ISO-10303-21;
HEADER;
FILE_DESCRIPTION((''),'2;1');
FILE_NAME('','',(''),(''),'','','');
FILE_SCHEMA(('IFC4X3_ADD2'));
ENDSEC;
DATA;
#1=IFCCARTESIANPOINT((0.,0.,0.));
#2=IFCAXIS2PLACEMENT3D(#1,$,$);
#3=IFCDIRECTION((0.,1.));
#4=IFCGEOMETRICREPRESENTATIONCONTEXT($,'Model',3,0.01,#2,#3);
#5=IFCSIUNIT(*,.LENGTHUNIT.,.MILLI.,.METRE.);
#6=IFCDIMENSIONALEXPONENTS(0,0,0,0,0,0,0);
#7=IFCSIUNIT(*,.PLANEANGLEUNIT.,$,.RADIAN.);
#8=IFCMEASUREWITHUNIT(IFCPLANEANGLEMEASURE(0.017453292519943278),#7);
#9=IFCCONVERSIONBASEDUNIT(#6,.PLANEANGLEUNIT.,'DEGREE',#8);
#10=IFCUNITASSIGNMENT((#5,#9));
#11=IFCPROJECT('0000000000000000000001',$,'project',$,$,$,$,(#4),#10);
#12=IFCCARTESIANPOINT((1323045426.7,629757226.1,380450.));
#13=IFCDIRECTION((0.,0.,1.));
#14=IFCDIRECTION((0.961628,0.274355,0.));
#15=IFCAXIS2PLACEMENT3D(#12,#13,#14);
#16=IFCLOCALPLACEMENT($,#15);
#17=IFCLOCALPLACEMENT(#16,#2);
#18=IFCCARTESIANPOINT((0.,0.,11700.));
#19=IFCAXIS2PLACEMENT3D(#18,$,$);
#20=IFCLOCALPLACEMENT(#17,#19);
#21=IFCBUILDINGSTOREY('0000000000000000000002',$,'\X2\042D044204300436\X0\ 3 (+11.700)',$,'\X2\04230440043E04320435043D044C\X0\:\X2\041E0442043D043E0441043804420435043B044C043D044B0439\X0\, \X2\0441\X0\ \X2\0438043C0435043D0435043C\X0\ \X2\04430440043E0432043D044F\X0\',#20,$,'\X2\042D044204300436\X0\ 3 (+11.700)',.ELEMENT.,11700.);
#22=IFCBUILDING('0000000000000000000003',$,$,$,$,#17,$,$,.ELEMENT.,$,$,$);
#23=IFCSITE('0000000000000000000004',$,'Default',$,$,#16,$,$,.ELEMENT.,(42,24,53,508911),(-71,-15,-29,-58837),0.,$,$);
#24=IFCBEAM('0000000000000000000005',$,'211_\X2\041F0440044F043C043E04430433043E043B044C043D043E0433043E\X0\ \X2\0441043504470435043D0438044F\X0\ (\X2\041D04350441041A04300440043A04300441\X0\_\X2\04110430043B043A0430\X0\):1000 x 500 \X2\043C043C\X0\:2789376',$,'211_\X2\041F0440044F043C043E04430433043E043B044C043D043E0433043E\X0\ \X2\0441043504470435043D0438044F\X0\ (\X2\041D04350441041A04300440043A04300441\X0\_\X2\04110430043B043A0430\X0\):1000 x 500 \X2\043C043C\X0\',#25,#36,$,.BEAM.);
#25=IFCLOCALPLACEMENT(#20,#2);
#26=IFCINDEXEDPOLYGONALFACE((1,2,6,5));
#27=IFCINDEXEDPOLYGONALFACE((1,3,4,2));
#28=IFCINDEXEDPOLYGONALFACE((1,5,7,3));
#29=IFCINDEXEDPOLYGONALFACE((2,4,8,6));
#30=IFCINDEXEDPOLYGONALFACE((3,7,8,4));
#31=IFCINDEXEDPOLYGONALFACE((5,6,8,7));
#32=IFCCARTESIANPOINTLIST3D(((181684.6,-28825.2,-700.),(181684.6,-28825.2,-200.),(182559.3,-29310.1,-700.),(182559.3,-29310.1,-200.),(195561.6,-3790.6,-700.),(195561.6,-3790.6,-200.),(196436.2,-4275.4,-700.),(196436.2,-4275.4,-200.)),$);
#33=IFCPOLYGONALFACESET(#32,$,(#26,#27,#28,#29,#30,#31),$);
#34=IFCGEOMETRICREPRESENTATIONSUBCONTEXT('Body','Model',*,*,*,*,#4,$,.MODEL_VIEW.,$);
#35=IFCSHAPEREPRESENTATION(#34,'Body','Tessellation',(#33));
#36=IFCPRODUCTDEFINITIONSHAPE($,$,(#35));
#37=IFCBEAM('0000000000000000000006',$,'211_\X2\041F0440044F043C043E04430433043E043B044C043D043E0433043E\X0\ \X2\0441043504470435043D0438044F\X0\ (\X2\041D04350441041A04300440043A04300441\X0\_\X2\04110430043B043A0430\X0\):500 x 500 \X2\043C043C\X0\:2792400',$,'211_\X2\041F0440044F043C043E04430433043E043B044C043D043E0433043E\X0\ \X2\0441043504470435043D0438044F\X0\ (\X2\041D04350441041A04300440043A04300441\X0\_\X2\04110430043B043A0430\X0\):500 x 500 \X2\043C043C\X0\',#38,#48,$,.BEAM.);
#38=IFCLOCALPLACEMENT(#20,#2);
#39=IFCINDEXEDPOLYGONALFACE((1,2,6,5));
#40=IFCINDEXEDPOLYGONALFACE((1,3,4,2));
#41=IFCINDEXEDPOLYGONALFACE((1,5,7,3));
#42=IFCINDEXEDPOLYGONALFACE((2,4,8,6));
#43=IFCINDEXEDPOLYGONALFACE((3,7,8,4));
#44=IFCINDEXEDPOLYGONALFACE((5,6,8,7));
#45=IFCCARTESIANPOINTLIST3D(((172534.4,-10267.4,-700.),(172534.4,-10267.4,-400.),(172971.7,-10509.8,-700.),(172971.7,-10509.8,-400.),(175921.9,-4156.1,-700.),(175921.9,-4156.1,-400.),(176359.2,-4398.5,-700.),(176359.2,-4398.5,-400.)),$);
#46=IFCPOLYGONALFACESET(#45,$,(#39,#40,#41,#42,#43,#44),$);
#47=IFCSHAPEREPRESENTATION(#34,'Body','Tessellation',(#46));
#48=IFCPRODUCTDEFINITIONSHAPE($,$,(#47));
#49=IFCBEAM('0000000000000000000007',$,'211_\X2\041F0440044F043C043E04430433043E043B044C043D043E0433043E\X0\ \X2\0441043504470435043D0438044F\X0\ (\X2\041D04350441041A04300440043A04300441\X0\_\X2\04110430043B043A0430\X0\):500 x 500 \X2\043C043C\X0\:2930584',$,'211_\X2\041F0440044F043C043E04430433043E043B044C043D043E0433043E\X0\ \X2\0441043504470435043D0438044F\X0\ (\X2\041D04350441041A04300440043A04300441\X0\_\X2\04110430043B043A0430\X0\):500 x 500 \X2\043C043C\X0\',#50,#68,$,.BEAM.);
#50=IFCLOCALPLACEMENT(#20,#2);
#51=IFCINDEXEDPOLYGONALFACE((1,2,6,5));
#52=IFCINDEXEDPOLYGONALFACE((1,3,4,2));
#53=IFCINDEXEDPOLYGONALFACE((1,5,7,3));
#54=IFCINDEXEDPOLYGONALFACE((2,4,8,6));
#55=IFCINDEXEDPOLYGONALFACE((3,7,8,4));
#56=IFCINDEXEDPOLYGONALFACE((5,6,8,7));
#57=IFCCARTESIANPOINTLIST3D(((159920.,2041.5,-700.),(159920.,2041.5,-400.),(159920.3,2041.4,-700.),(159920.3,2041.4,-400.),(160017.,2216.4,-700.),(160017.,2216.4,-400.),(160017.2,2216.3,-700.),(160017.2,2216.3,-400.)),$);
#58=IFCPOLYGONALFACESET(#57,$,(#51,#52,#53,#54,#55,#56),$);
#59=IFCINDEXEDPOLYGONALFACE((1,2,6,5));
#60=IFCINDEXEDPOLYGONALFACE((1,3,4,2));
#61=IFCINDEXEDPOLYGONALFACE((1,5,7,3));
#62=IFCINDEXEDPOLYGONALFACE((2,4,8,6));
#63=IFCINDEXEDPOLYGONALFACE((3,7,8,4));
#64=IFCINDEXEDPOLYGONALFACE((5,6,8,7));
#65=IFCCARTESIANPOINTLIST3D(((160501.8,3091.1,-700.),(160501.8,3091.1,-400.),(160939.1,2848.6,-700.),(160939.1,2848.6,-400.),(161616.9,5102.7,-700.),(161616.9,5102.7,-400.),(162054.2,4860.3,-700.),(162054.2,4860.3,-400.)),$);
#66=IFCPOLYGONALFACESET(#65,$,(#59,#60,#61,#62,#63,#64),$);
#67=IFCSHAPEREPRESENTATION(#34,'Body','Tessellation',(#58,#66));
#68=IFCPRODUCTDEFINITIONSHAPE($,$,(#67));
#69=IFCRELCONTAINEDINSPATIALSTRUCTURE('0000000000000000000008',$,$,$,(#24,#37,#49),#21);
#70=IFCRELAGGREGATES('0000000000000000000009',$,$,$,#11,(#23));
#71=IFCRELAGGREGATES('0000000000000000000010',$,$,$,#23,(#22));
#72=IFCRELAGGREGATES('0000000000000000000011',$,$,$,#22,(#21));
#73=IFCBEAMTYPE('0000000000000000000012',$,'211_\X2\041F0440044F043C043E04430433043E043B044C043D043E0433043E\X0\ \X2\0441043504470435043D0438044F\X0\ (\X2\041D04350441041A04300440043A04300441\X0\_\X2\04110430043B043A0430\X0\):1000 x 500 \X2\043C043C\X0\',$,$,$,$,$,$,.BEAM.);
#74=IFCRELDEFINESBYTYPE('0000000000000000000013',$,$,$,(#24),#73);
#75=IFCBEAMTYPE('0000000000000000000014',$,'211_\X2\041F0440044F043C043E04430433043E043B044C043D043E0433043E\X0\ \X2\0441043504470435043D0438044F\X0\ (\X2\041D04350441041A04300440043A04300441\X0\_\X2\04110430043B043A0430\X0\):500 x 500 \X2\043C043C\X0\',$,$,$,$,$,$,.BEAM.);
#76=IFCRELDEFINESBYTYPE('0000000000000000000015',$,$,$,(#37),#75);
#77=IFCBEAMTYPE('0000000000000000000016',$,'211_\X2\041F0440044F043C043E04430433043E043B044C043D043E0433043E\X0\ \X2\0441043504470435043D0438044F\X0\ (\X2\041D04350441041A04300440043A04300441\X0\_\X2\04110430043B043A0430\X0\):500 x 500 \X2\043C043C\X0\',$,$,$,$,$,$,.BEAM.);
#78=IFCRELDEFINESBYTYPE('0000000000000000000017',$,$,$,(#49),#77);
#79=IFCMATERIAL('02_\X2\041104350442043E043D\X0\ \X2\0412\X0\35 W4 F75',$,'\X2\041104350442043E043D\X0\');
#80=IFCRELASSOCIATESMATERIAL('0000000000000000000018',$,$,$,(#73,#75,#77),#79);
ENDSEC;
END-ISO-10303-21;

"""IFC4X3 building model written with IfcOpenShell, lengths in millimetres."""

from ifc_helpers import new_model, entity, si_unit, converted_unit, direction, frame, frame_2d, origin, place, context, subcontext, project, spatial, polyline, segment, composite_curve, rectangle, outline, extrude, source, transform, mapped, material, material_profile, profile_set, type_object, type_shapes, element, save


model = new_model("IFC4X3")

# Units and contexts
model_context = context("Model", 3, precision=0.01, world=origin(), true_north=direction((0.0, 1.0)))
body_context = subcontext(model_context, "Body", "Model", "MODEL_VIEW")
ifc_project = project(units=[si_unit("LENGTHUNIT", "METRE", prefix="MILLI"), converted_unit("PLANEANGLEUNIT", "DEGREE", entity("IfcPlaneAngleMeasure", 0.017453292519943278), si_unit("PLANEANGLEUNIT", "RADIAN"), dimensions=[0, 0, 0, 0, 0, 0, 0])], contexts=[model_context])

# Site, building, storey
site_placement = place(None, frame((1323045426.7, 629757226.1, 380450.0), z_axis=(0.0, 0.0, 1.0), x_axis=(0.961628, 0.274355, 0.0)))
site = spatial("IfcSite", under=ifc_project, at=site_placement, Name="Default", CompositionType="ELEMENT", RefLatitude=(42, 24, 53, 508911), RefLongitude=(-71, -15, -29, -58837), RefElevation=0.0)
building_placement = place(site_placement, origin())
building = spatial("IfcBuilding", under=site, at=building_placement, CompositionType="ELEMENT")
storey_placement = place(building_placement, frame((0.0, 0.0, 11700.0)))
storey = spatial("IfcBuildingStorey", under=building, at=storey_placement, Name="Этаж 3 (+11.700)", ObjectType="Уровень:Относительный, с именем уровня", LongName="Этаж 3 (+11.700)", CompositionType="ELEMENT", Elevation=11700.0)

# Beams
ifc_material = material(Name="02_Бетон В35 W4 F75", Category="Бетон")
ifc_material_profile_1 = material_profile(ifc_material, outline(composite_curve([segment(polyline([(-500.0, 50.0, 0.0), (500.0, 50.0, 0.0)]), True, "CONTINUOUS"), segment(polyline([(500.0, 50.0, 0.0), (500.0, -250.0, 0.0)]), True, "CONTINUOUS"), segment(polyline([(500.0, -250.0, 0.0), (-500.0, -250.0, 0.0)]), True, "CONTINUOUS"), segment(polyline([(-500.0, -250.0, 0.0), (-500.0, 50.0, 0.0)]), True, "CONTINUOUS")], self_intersect=False), kind="CURVE"), Name="1000 x 500 мм")
ifc_profile_set_1 = profile_set([ifc_material_profile_1], Name="1000 x 500 мм")
beam_type_1 = type_object("IfcBeamType", Name="211_Прямоугольного сечения (НесКаркас_Балка):1000 x 500 мм", PredefinedType="BEAM", material=ifc_profile_set_1)
shared_shape_1 = source(origin(), body_context, "Body", "SweptSolid", [
    extrude(rectangle(XDim=500.0, YDim=1000.0, at=frame_2d((0.0, 0.0), x_axis=(1.0, 0.0))), frame((195998.9, -4033.0, 11250.0), z_axis=(-0.48481, -0.87462, 0.0), x_axis=(0.0, 0.0, -1.0)), (0.0, 0.0, 1.0), 28623.5),
])
type_shapes(beam_type_1, [shared_shape_1])
beam_1_placement = place(storey_placement, frame((0.0, 0.0, -11700.0)))
element("IfcBeam", 1, at=beam_1_placement, inside=storey, type_object=beam_type_1, Name="211_Прямоугольного сечения (НесКаркас_Балка):1000 x 500 мм:2789376", ObjectType="211_Прямоугольного сечения (НесКаркас_Балка):1000 x 500 мм", PredefinedType="BEAM", context=body_context, shape_type="MappedRepresentation", body=[
    mapped(shared_shape_1, transform((0.0, 0.0, 0.0), scale=1.0)),
])
ifc_material_profile_2 = material_profile(ifc_material, rectangle(XDim=300.0, YDim=500.0, at=frame_2d((0.0, 0.0), x_axis=(1.0, 0.0))), Name="500 x 500 мм")
ifc_profile_set_2 = profile_set([ifc_material_profile_2], Name="500 x 500 мм")
beam_type_2 = type_object("IfcBeamType", Name="211_Прямоугольного сечения (НесКаркас_Балка):500 x 500 мм", PredefinedType="BEAM", material=ifc_profile_set_2)
shared_shape_2 = source(origin(), body_context, "Body", "SweptSolid", [
    extrude(rectangle(XDim=300.0, YDim=500.0, at=frame_2d((0.0, 0.0), x_axis=(1.0, 0.0))), frame((176140.6, -4277.3, 11150.0), z_axis=(-0.48481, -0.87462, 0.0), x_axis=(0.0, 0.0, -1.0)), (0.0, 0.0, 1.0), 6987.3),
])
type_shapes(beam_type_2, [shared_shape_2])
beam_2_placement = place(storey_placement, frame((0.0, 0.0, -11700.0)))
element("IfcBeam", 2, at=beam_2_placement, inside=storey, type_object=beam_type_2, Name="211_Прямоугольного сечения (НесКаркас_Балка):500 x 500 мм:2792400", ObjectType="211_Прямоугольного сечения (НесКаркас_Балка):500 x 500 мм", PredefinedType="BEAM", context=body_context, shape_type="MappedRepresentation", body=[
    mapped(shared_shape_2, transform((0.0, 0.0, 0.0), scale=1.0)),
])
beam_type_3 = type_object("IfcBeamType", Name="211_Прямоугольного сечения (НесКаркас_Балка):500 x 500 мм", PredefinedType="BEAM", material=ifc_profile_set_2)
shared_shape_3 = source(origin(), body_context, "Body", "SweptSolid", [
    extrude(rectangle(XDim=300.0, YDim=0.2, at=frame_2d((0.0, 0.0), x_axis=(1.0, 0.0))), frame((159920.1, 2041.4, 11150.0), z_axis=(-0.48481, -0.87462, 0.0), x_axis=(0.0, 0.0, 1.0)), (0.0, 0.0, -1.0), 200.0),
    extrude(rectangle(XDim=300.0, YDim=500.0, at=frame_2d((0.0, 0.0), x_axis=(1.0, 0.0))), frame((160720.5, 2969.8, 11150.0), z_axis=(0.48481, 0.87462, 0.0), x_axis=(0.0, 0.0, 1.0)), (0.0, 0.0, 1.0), 2300.0),
])
type_shapes(beam_type_3, [shared_shape_3])
beam_3_placement = place(storey_placement, frame((0.0, 0.0, -11700.0)))
element("IfcBeam", 3, at=beam_3_placement, inside=storey, type_object=beam_type_3, Name="211_Прямоугольного сечения (НесКаркас_Балка):500 x 500 мм:2930584", ObjectType="211_Прямоугольного сечения (НесКаркас_Балка):500 x 500 мм", PredefinedType="BEAM", context=body_context, shape_type="MappedRepresentation", body=[
    mapped(shared_shape_3, transform((0.0, 0.0, 0.0), scale=1.0)),
])

save(model, "model.ifc")
